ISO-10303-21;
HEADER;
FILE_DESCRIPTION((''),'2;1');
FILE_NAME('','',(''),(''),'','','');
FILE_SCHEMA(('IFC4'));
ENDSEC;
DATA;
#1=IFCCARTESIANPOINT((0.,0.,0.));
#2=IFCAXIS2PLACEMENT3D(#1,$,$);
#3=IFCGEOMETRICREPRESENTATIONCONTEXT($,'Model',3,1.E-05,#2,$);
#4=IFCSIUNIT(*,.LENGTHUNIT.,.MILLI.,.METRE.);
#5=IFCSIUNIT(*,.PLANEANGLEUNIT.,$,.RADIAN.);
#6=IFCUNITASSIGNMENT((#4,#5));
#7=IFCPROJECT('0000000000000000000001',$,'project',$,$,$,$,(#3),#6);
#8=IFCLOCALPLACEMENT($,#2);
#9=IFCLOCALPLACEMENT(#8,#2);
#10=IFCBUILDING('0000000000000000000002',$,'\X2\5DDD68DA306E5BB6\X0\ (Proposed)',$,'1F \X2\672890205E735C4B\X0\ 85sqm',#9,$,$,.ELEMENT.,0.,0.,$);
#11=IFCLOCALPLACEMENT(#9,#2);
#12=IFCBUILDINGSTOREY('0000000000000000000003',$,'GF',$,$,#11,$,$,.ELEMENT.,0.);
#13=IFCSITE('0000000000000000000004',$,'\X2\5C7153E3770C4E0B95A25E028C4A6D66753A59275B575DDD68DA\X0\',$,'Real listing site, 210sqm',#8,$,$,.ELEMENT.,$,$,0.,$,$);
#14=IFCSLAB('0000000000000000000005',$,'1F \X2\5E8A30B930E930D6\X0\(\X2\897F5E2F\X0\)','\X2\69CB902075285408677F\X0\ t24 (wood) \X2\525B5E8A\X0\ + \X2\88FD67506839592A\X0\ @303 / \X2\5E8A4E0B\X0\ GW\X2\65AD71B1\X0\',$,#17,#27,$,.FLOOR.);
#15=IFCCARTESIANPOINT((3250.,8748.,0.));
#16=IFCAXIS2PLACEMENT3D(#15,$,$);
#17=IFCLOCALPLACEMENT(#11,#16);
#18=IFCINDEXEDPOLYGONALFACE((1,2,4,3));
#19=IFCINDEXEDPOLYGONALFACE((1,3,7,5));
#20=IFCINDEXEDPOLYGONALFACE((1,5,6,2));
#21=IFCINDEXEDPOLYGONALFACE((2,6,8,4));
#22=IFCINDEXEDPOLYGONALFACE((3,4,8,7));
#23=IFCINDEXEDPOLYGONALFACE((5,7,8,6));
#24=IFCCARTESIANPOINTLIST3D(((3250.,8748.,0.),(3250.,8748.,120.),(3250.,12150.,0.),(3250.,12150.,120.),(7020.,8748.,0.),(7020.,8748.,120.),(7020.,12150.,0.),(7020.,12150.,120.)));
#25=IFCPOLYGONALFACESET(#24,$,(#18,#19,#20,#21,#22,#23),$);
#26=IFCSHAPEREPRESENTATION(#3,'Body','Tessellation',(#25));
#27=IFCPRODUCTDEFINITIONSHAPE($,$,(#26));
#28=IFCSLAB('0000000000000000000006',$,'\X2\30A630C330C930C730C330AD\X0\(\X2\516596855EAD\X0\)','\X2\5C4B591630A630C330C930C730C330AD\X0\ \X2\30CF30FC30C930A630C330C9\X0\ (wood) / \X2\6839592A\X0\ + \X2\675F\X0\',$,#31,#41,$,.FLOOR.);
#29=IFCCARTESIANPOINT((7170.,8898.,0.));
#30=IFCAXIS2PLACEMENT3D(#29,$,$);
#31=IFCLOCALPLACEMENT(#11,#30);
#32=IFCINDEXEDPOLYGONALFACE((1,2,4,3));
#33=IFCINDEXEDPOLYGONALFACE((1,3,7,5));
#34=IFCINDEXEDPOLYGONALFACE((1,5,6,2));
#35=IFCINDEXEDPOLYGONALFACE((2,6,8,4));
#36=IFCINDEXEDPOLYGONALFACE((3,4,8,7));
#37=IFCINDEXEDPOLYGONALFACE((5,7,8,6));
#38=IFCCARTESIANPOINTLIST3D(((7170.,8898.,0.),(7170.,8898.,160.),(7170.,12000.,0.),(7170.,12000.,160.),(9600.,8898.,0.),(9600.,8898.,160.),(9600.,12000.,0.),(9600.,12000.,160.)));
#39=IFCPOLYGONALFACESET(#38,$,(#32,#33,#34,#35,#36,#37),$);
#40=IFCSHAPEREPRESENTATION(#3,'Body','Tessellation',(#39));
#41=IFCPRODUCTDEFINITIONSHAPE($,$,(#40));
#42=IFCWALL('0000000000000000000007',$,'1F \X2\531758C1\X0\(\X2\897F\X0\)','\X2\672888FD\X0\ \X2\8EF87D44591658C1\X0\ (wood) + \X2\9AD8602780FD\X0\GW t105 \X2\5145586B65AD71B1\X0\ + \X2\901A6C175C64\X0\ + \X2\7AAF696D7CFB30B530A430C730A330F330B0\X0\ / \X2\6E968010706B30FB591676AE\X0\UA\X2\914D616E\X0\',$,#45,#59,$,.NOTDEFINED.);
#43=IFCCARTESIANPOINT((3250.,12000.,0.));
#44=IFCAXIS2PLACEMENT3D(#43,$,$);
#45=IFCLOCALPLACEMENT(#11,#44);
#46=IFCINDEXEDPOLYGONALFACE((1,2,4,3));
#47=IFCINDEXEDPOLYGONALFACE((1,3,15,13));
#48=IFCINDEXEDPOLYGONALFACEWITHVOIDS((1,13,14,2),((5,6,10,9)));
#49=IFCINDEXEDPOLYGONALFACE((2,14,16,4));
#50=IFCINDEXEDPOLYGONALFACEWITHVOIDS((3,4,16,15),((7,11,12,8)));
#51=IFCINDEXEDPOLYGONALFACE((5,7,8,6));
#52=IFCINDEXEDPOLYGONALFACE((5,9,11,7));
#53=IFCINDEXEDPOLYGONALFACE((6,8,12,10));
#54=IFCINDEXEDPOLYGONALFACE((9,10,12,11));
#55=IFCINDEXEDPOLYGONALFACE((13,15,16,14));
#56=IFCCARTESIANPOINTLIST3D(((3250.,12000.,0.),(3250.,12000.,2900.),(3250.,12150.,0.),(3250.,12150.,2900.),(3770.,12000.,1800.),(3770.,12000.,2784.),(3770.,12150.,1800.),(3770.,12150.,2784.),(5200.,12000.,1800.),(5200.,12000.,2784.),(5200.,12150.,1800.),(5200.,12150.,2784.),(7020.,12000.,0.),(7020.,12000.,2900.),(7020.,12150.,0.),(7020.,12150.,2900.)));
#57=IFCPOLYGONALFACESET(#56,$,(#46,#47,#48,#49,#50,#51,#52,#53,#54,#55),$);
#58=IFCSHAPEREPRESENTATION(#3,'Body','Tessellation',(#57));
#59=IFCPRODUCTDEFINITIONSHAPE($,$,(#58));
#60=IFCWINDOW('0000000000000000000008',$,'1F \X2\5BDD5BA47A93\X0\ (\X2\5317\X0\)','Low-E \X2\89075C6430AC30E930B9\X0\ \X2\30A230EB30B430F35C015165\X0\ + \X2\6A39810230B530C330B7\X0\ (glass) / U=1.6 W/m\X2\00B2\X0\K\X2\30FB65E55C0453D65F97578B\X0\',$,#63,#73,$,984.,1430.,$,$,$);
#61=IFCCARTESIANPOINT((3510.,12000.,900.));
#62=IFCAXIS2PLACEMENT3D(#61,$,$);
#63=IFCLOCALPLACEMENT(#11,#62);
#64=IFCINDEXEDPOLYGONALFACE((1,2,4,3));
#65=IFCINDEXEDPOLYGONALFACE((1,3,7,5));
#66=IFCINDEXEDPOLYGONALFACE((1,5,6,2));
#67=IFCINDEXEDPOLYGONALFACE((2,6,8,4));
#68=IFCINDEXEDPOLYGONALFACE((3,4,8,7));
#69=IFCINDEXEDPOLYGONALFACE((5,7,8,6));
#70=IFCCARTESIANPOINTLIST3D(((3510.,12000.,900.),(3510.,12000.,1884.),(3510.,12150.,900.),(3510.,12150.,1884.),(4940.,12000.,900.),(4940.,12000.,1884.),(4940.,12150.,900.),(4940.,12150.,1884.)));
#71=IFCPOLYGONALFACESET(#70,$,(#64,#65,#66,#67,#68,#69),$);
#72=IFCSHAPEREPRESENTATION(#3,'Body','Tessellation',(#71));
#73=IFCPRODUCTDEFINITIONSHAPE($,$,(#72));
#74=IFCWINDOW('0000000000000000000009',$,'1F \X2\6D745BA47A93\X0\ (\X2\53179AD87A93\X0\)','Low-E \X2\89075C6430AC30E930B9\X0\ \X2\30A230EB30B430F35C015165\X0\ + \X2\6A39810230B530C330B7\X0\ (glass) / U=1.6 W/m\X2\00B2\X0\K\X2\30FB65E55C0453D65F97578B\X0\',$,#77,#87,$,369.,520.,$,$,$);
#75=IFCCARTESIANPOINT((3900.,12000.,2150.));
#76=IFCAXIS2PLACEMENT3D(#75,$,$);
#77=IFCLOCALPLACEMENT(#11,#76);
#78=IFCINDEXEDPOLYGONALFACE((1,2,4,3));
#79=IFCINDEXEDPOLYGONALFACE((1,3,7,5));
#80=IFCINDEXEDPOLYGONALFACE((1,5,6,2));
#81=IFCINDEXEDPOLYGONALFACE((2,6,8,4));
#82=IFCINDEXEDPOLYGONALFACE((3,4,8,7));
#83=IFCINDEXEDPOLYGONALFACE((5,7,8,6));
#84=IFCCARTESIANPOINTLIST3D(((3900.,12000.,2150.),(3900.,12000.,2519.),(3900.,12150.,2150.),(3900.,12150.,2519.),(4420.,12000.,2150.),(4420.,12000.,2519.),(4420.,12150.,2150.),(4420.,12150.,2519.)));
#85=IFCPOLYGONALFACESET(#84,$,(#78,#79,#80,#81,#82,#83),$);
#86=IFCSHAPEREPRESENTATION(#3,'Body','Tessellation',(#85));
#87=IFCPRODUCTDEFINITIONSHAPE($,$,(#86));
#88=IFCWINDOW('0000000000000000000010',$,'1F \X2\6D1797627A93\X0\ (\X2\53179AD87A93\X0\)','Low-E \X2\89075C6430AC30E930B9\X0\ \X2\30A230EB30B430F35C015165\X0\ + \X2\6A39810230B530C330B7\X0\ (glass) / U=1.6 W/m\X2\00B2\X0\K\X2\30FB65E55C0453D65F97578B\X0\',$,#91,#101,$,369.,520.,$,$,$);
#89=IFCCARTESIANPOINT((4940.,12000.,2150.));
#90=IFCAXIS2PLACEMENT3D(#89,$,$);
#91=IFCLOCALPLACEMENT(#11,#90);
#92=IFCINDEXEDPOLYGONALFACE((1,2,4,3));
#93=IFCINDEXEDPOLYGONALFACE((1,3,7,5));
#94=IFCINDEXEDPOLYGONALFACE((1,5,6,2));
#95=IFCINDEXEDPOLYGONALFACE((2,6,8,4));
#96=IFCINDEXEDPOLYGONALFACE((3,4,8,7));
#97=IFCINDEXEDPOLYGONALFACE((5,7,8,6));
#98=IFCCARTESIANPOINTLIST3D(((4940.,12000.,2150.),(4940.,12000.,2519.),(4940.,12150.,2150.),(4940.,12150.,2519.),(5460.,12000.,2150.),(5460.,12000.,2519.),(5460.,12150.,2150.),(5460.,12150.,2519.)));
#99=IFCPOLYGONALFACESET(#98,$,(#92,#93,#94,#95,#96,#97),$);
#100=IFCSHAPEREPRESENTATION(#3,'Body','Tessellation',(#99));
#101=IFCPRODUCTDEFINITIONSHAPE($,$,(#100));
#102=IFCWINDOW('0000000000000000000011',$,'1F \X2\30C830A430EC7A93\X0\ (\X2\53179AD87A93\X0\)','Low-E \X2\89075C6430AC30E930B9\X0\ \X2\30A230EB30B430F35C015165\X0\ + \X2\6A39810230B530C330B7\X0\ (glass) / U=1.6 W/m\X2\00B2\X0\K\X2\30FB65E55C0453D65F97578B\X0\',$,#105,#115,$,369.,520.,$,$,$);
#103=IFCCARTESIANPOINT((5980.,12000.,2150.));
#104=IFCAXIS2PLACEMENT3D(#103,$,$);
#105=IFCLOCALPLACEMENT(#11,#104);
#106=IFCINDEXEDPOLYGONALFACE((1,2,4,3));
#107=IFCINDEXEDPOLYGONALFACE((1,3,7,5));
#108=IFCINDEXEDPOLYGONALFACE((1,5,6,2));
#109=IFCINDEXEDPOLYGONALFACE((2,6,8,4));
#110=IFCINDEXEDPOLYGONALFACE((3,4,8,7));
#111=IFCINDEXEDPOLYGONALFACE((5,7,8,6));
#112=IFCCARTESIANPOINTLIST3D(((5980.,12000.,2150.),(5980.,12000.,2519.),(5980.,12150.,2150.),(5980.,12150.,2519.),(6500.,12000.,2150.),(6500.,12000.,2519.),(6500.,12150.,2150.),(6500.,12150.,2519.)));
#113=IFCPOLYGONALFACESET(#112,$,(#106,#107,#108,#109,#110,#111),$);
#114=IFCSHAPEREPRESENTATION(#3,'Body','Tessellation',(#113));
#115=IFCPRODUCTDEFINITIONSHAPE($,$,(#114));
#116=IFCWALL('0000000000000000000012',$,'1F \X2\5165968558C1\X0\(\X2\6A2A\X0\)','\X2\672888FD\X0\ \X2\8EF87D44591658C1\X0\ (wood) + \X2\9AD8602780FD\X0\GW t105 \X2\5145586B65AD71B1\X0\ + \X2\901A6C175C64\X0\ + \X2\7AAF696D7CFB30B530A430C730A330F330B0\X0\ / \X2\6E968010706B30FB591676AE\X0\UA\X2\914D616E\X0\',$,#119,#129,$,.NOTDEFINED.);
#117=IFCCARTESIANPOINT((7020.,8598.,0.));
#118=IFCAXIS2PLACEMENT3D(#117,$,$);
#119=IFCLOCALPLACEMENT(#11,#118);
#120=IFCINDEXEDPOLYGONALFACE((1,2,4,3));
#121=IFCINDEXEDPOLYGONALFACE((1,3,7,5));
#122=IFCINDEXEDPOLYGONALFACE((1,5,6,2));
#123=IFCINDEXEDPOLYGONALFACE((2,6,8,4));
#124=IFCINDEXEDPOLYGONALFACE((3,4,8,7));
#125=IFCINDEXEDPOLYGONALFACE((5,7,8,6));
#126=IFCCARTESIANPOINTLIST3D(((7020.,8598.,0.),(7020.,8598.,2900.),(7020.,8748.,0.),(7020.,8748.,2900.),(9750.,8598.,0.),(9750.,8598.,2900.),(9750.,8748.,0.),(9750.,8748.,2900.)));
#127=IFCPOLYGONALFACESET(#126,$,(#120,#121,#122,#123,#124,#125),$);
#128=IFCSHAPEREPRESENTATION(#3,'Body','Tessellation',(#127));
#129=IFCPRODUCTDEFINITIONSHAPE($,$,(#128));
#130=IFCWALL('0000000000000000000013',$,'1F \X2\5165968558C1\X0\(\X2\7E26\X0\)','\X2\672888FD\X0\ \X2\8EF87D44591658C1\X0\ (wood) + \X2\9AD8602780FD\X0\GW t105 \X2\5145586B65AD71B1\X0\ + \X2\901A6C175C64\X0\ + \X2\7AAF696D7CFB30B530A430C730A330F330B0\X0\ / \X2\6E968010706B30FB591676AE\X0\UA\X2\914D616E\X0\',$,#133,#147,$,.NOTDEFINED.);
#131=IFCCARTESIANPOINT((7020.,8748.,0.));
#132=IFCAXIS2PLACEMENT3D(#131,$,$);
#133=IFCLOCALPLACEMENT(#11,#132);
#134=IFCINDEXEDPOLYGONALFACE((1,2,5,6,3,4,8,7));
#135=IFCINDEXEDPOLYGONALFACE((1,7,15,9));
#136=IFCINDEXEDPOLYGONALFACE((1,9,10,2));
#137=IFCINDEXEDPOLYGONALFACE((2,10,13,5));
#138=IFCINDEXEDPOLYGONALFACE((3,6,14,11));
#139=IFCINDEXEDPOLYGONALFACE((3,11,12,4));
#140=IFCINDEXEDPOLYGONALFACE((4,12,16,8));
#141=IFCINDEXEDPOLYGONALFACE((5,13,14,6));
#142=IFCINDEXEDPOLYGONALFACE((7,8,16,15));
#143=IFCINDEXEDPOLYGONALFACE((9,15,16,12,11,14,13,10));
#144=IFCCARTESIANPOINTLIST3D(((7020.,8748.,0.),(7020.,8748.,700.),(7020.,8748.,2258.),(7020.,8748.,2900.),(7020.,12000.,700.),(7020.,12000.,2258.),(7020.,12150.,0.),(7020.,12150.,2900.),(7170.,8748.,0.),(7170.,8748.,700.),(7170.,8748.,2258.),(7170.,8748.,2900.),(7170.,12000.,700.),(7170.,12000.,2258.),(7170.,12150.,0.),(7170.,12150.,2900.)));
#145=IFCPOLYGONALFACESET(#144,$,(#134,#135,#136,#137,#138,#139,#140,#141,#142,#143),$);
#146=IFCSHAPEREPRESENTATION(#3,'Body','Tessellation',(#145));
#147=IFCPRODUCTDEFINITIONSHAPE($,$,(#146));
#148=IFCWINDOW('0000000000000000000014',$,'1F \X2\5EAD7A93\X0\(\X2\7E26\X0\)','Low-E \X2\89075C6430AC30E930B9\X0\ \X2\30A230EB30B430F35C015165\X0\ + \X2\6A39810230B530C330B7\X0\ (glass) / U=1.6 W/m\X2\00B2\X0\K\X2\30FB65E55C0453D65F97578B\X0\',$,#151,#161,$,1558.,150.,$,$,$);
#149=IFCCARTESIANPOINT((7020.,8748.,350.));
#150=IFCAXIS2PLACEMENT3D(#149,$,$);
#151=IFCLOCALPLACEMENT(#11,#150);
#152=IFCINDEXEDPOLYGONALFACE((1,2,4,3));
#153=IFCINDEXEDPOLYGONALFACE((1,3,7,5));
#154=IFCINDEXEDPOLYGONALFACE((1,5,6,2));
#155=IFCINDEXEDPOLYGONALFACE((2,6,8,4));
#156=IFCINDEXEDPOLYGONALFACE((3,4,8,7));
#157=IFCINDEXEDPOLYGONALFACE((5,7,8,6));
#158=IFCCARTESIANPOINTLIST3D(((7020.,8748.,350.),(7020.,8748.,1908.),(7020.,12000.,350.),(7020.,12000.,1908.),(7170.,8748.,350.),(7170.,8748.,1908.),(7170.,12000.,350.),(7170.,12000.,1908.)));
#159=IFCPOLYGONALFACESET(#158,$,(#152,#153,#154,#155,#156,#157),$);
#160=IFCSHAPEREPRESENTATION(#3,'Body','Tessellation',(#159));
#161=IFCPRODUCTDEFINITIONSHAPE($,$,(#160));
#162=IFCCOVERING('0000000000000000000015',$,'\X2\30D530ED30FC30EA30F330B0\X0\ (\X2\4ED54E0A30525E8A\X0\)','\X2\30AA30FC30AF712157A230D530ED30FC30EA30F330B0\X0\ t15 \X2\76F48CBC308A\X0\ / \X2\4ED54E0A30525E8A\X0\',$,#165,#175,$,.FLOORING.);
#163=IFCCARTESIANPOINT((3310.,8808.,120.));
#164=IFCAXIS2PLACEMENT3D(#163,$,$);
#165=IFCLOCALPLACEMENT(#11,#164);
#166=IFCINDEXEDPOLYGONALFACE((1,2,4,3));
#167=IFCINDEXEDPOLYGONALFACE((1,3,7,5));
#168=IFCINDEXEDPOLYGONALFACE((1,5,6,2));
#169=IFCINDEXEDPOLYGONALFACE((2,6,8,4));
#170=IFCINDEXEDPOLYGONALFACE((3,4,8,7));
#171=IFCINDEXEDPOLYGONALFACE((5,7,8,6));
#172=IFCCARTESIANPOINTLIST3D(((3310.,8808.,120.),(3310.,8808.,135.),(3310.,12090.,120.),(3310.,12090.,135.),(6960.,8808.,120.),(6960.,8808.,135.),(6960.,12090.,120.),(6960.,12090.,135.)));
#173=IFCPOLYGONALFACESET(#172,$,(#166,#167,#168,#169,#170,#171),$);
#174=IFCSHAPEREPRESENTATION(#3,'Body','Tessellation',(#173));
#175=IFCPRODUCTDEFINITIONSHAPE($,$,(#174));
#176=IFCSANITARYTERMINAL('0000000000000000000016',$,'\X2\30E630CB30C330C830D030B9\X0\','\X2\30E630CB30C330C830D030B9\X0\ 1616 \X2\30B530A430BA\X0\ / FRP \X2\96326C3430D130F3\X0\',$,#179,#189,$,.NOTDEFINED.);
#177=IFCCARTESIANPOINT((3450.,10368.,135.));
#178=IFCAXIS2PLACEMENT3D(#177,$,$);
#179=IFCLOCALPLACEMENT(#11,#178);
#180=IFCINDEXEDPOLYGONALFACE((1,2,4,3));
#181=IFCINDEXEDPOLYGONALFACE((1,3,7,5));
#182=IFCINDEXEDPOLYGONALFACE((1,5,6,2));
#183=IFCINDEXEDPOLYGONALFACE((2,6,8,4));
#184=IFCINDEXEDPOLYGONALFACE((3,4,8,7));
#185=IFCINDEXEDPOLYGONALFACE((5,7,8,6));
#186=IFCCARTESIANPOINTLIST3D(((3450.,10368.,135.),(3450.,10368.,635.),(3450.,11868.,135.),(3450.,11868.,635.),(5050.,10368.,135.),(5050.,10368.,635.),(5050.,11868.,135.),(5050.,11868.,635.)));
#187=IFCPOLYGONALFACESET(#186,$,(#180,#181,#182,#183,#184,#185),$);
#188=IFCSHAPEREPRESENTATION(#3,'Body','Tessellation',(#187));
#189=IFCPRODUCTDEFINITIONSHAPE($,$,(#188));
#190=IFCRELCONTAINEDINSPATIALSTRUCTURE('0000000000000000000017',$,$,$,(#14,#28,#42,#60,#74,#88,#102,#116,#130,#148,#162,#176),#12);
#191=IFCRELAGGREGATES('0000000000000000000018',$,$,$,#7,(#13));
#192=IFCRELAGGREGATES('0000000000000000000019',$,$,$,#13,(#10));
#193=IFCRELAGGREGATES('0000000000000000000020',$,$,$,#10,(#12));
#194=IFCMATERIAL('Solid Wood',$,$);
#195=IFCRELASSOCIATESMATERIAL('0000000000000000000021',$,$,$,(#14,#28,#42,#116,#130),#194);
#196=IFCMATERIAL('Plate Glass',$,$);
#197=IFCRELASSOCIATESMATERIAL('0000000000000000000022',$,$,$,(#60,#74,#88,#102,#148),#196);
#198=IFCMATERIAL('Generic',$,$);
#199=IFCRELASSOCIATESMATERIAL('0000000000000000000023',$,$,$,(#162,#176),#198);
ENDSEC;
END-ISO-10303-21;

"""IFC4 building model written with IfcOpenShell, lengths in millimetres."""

from ifc_helpers import new_model, si_unit, frame, frame_2d, origin, place, context, project, spatial, rectangle, extrude, material, element, fill, save


model = new_model("IFC4")

# Units and contexts
model_context = context("Model", 3, precision=1e-05, world=origin())
ifc_project = project(units=[si_unit("LENGTHUNIT", "METRE", prefix="MILLI"), si_unit("PLANEANGLEUNIT", "RADIAN")], contexts=[model_context])

# Site, building, storey
site_placement = place(None, origin())
site = spatial("IfcSite", under=ifc_project, at=site_placement, Name="山口県下関市豊浦町大字川棚", ObjectType="Real listing site, 210sqm", CompositionType="ELEMENT", RefElevation=0.0)
building_placement = place(site_placement, origin())
building = spatial("IfcBuilding", under=site, at=building_placement, Name="川棚の家 (Proposed)", ObjectType="1F 木造平屋 85sqm", CompositionType="ELEMENT", ElevationOfRefHeight=0.0, ElevationOfTerrain=0.0)
storey_placement = place(building_placement, origin())
storey = spatial("IfcBuildingStorey", under=building, at=storey_placement, Name="GF", CompositionType="ELEMENT", Elevation=0.0)

# Slabs
ifc_material_1 = material(Name="Solid Wood")
slab_1_placement = place(storey_placement, frame((3250.0, 8748.0, 0.0)))
element("IfcSlab", 1, at=slab_1_placement, inside=storey, material=ifc_material_1, Name="1F 床スラブ(西帯)", Description="構造用合板 t24 (wood) 剛床 + 製材根太 @303 / 床下 GW断熱", PredefinedType="FLOOR", context=model_context, shape_type="SweptSolid", body=[
    extrude(rectangle(XDim=3770.0, YDim=3402.0, at=frame_2d((1885.0, 1701.0))), frame((3250.0, 8748.0, 0.0)), (0.0, 0.0, 1.0), 120.0),
])
slab_2_placement = place(storey_placement, frame((7170.0, 8898.0, 0.0)))
element("IfcSlab", 2, at=slab_2_placement, inside=storey, material=ifc_material_1, Name="ウッドデッキ(入隅庭)", Description="屋外ウッドデッキ ハードウッド (wood) / 根太 + 束", PredefinedType="FLOOR", context=model_context, shape_type="SweptSolid", body=[
    extrude(rectangle(XDim=2430.0, YDim=3102.0, at=frame_2d((1215.0, 1551.0))), frame((7170.0, 8898.0, 0.0)), (0.0, 0.0, 1.0), 160.0),
])

# Wall, openings, windows
wall_1_placement = place(storey_placement, frame((3250.0, 12000.0, 0.0)))
wall_1 = element("IfcWall", 3, at=wall_1_placement, inside=storey, material=ifc_material_1, Name="1F 北壁(西)", Description="木製 軸組外壁 (wood) + 高性能GW t105 充填断熱 + 通気層 + 窯業系サイディング / 準耐火・外皮UA配慮", PredefinedType="NOTDEFINED", context=model_context, shape_type="SweptSolid", body=[
    extrude(rectangle(XDim=3770.0, YDim=150.0, at=frame_2d((1885.0, 75.0))), frame((3250.0, 12000.0, 0.0)), (0.0, 0.0, 1.0), 2900.0),
])
opening_1_placement = place(storey_placement, frame((3510.0, 12000.0, 900.0)))
opening_1 = element("IfcOpeningElement", 4, at=opening_1_placement, cuts=wall_1, PredefinedType="NOTDEFINED", context=model_context, shape_type="SweptSolid", body=[
    extrude(rectangle(XDim=1430.0, YDim=150.0, at=frame_2d((715.0, 75.0))), frame((3510.0, 12000.0, 900.0)), (0.0, 0.0, 1.0), 984.0),
])
opening_2_placement = place(storey_placement, frame((3900.0, 12000.0, 2150.0)))
opening_2 = element("IfcOpeningElement", 5, at=opening_2_placement, cuts=wall_1, PredefinedType="NOTDEFINED", context=model_context, shape_type="SweptSolid", body=[
    extrude(rectangle(XDim=520.0, YDim=150.0, at=frame_2d((260.0, 75.0))), frame((3900.0, 12000.0, 2150.0)), (0.0, 0.0, 1.0), 369.0),
])
opening_3_placement = place(storey_placement, frame((4940.0, 12000.0, 2150.0)))
opening_3 = element("IfcOpeningElement", 6, at=opening_3_placement, cuts=wall_1, PredefinedType="NOTDEFINED", context=model_context, shape_type="SweptSolid", body=[
    extrude(rectangle(XDim=520.0, YDim=150.0, at=frame_2d((260.0, 75.0))), frame((4940.0, 12000.0, 2150.0)), (0.0, 0.0, 1.0), 369.0),
])
opening_4_placement = place(storey_placement, frame((5980.0, 12000.0, 2150.0)))
opening_4 = element("IfcOpeningElement", 7, at=opening_4_placement, cuts=wall_1, PredefinedType="NOTDEFINED", context=model_context, shape_type="SweptSolid", body=[
    extrude(rectangle(XDim=520.0, YDim=150.0, at=frame_2d((260.0, 75.0))), frame((5980.0, 12000.0, 2150.0)), (0.0, 0.0, 1.0), 369.0),
])
ifc_material_2 = material(Name="Plate Glass")
window_1_placement = place(storey_placement, frame((3510.0, 12000.0, 900.0)))
window_1 = element("IfcWindow", 8, at=window_1_placement, inside=storey, material=ifc_material_2, Name="1F 寝室窓 (北)", Description="Low-E 複層ガラス アルゴン封入 + 樹脂サッシ (glass) / U=1.6 W/m²K・日射取得型", OverallHeight=984.0, OverallWidth=1430.0, context=model_context, shape_type="SweptSolid", body=[
    extrude(rectangle(XDim=1430.0, YDim=150.0, at=frame_2d((715.0, 75.0))), frame((3510.0, 12000.0, 900.0)), (0.0, 0.0, 1.0), 984.0),
])
fill(opening_1, window_1)
window_2_placement = place(storey_placement, frame((3900.0, 12000.0, 2150.0)))
window_2 = element("IfcWindow", 9, at=window_2_placement, inside=storey, material=ifc_material_2, Name="1F 浴室窓 (北高窓)", Description="Low-E 複層ガラス アルゴン封入 + 樹脂サッシ (glass) / U=1.6 W/m²K・日射取得型", OverallHeight=369.0, OverallWidth=520.0, context=model_context, shape_type="SweptSolid", body=[
    extrude(rectangle(XDim=520.0, YDim=150.0, at=frame_2d((260.0, 75.0))), frame((3900.0, 12000.0, 2150.0)), (0.0, 0.0, 1.0), 369.0),
])
fill(opening_2, window_2)
window_3_placement = place(storey_placement, frame((4940.0, 12000.0, 2150.0)))
window_3 = element("IfcWindow", 10, at=window_3_placement, inside=storey, material=ifc_material_2, Name="1F 洗面窓 (北高窓)", Description="Low-E 複層ガラス アルゴン封入 + 樹脂サッシ (glass) / U=1.6 W/m²K・日射取得型", OverallHeight=369.0, OverallWidth=520.0, context=model_context, shape_type="SweptSolid", body=[
    extrude(rectangle(XDim=520.0, YDim=150.0, at=frame_2d((260.0, 75.0))), frame((4940.0, 12000.0, 2150.0)), (0.0, 0.0, 1.0), 369.0),
])
fill(opening_3, window_3)
window_4_placement = place(storey_placement, frame((5980.0, 12000.0, 2150.0)))
window_4 = element("IfcWindow", 11, at=window_4_placement, inside=storey, material=ifc_material_2, Name="1F トイレ窓 (北高窓)", Description="Low-E 複層ガラス アルゴン封入 + 樹脂サッシ (glass) / U=1.6 W/m²K・日射取得型", OverallHeight=369.0, OverallWidth=520.0, context=model_context, shape_type="SweptSolid", body=[
    extrude(rectangle(XDim=520.0, YDim=150.0, at=frame_2d((260.0, 75.0))), frame((5980.0, 12000.0, 2150.0)), (0.0, 0.0, 1.0), 369.0),
])
fill(opening_4, window_4)

# Wall
wall_2_placement = place(storey_placement, frame((7020.0, 8598.0, 0.0)))
element("IfcWall", 12, at=wall_2_placement, inside=storey, material=ifc_material_1, Name="1F 入隅壁(横)", Description="木製 軸組外壁 (wood) + 高性能GW t105 充填断熱 + 通気層 + 窯業系サイディング / 準耐火・外皮UA配慮", PredefinedType="NOTDEFINED", context=model_context, shape_type="SweptSolid", body=[
    extrude(rectangle(XDim=2730.0, YDim=150.0, at=frame_2d((1365.0, 75.0))), frame((7020.0, 8598.0, 0.0)), (0.0, 0.0, 1.0), 2900.0),
])

# Wall, opening, window
wall_3_placement = place(storey_placement, frame((7020.0, 8748.0, 0.0)))
wall_3 = element("IfcWall", 13, at=wall_3_placement, inside=storey, material=ifc_material_1, Name="1F 入隅壁(縦)", Description="木製 軸組外壁 (wood) + 高性能GW t105 充填断熱 + 通気層 + 窯業系サイディング / 準耐火・外皮UA配慮", PredefinedType="NOTDEFINED", context=model_context, shape_type="SweptSolid", body=[
    extrude(rectangle(XDim=150.0, YDim=3402.0, at=frame_2d((75.0, 1701.0))), frame((7020.0, 8748.0, 0.0)), (0.0, 0.0, 1.0), 2900.0),
])
opening_5_placement = place(storey_placement, frame((7020.0, 8748.0, 350.0)))
opening_5 = element("IfcOpeningElement", 14, at=opening_5_placement, cuts=wall_3, PredefinedType="NOTDEFINED", context=model_context, shape_type="SweptSolid", body=[
    extrude(rectangle(XDim=150.0, YDim=3252.0, at=frame_2d((75.0, 1626.0))), frame((7020.0, 8748.0, 350.0)), (0.0, 0.0, 1.0), 1558.0),
])
window_5_placement = place(storey_placement, frame((7020.0, 8748.0, 350.0)))
window_5 = element("IfcWindow", 15, at=window_5_placement, inside=storey, material=ifc_material_2, Name="1F 庭窓(縦)", Description="Low-E 複層ガラス アルゴン封入 + 樹脂サッシ (glass) / U=1.6 W/m²K・日射取得型", OverallHeight=1558.0, OverallWidth=150.0, context=model_context, shape_type="SweptSolid", body=[
    extrude(rectangle(XDim=150.0, YDim=3252.0, at=frame_2d((75.0, 1626.0))), frame((7020.0, 8748.0, 350.0)), (0.0, 0.0, 1.0), 1558.0),
])
fill(opening_5, window_5)

# Covering
ifc_material_3 = material(Name="Generic")
covering_placement = place(storey_placement, frame((3310.0, 8808.0, 120.0)))
element("IfcCovering", 16, at=covering_placement, inside=storey, material=ifc_material_3, Name="フローリング (仕上げ床)", Description="オーク無垢フローリング t15 直貼り / 仕上げ床", PredefinedType="FLOORING", context=model_context, shape_type="SweptSolid", body=[
    extrude(rectangle(XDim=3650.0, YDim=3282.0, at=frame_2d((1825.0, 1641.0))), frame((3310.0, 8808.0, 120.0)), (0.0, 0.0, 1.0), 15.0),
])

# Sanitary terminal
sanitary_terminal_1_placement = place(storey_placement, frame((3450.0, 10368.0, 135.0)))
element("IfcSanitaryTerminal", 17, at=sanitary_terminal_1_placement, inside=storey, material=ifc_material_3, Name="ユニットバス", Description="ユニットバス 1616 サイズ / FRP 防水パン", PredefinedType="NOTDEFINED", context=model_context, shape_type="SweptSolid", body=[
    extrude(rectangle(XDim=1600.0, YDim=1500.0, at=frame_2d((800.0, 750.0))), frame((3450.0, 10368.0, 135.0)), (0.0, 0.0, 1.0), 500.0),
])

save(model, "model.ifc")
